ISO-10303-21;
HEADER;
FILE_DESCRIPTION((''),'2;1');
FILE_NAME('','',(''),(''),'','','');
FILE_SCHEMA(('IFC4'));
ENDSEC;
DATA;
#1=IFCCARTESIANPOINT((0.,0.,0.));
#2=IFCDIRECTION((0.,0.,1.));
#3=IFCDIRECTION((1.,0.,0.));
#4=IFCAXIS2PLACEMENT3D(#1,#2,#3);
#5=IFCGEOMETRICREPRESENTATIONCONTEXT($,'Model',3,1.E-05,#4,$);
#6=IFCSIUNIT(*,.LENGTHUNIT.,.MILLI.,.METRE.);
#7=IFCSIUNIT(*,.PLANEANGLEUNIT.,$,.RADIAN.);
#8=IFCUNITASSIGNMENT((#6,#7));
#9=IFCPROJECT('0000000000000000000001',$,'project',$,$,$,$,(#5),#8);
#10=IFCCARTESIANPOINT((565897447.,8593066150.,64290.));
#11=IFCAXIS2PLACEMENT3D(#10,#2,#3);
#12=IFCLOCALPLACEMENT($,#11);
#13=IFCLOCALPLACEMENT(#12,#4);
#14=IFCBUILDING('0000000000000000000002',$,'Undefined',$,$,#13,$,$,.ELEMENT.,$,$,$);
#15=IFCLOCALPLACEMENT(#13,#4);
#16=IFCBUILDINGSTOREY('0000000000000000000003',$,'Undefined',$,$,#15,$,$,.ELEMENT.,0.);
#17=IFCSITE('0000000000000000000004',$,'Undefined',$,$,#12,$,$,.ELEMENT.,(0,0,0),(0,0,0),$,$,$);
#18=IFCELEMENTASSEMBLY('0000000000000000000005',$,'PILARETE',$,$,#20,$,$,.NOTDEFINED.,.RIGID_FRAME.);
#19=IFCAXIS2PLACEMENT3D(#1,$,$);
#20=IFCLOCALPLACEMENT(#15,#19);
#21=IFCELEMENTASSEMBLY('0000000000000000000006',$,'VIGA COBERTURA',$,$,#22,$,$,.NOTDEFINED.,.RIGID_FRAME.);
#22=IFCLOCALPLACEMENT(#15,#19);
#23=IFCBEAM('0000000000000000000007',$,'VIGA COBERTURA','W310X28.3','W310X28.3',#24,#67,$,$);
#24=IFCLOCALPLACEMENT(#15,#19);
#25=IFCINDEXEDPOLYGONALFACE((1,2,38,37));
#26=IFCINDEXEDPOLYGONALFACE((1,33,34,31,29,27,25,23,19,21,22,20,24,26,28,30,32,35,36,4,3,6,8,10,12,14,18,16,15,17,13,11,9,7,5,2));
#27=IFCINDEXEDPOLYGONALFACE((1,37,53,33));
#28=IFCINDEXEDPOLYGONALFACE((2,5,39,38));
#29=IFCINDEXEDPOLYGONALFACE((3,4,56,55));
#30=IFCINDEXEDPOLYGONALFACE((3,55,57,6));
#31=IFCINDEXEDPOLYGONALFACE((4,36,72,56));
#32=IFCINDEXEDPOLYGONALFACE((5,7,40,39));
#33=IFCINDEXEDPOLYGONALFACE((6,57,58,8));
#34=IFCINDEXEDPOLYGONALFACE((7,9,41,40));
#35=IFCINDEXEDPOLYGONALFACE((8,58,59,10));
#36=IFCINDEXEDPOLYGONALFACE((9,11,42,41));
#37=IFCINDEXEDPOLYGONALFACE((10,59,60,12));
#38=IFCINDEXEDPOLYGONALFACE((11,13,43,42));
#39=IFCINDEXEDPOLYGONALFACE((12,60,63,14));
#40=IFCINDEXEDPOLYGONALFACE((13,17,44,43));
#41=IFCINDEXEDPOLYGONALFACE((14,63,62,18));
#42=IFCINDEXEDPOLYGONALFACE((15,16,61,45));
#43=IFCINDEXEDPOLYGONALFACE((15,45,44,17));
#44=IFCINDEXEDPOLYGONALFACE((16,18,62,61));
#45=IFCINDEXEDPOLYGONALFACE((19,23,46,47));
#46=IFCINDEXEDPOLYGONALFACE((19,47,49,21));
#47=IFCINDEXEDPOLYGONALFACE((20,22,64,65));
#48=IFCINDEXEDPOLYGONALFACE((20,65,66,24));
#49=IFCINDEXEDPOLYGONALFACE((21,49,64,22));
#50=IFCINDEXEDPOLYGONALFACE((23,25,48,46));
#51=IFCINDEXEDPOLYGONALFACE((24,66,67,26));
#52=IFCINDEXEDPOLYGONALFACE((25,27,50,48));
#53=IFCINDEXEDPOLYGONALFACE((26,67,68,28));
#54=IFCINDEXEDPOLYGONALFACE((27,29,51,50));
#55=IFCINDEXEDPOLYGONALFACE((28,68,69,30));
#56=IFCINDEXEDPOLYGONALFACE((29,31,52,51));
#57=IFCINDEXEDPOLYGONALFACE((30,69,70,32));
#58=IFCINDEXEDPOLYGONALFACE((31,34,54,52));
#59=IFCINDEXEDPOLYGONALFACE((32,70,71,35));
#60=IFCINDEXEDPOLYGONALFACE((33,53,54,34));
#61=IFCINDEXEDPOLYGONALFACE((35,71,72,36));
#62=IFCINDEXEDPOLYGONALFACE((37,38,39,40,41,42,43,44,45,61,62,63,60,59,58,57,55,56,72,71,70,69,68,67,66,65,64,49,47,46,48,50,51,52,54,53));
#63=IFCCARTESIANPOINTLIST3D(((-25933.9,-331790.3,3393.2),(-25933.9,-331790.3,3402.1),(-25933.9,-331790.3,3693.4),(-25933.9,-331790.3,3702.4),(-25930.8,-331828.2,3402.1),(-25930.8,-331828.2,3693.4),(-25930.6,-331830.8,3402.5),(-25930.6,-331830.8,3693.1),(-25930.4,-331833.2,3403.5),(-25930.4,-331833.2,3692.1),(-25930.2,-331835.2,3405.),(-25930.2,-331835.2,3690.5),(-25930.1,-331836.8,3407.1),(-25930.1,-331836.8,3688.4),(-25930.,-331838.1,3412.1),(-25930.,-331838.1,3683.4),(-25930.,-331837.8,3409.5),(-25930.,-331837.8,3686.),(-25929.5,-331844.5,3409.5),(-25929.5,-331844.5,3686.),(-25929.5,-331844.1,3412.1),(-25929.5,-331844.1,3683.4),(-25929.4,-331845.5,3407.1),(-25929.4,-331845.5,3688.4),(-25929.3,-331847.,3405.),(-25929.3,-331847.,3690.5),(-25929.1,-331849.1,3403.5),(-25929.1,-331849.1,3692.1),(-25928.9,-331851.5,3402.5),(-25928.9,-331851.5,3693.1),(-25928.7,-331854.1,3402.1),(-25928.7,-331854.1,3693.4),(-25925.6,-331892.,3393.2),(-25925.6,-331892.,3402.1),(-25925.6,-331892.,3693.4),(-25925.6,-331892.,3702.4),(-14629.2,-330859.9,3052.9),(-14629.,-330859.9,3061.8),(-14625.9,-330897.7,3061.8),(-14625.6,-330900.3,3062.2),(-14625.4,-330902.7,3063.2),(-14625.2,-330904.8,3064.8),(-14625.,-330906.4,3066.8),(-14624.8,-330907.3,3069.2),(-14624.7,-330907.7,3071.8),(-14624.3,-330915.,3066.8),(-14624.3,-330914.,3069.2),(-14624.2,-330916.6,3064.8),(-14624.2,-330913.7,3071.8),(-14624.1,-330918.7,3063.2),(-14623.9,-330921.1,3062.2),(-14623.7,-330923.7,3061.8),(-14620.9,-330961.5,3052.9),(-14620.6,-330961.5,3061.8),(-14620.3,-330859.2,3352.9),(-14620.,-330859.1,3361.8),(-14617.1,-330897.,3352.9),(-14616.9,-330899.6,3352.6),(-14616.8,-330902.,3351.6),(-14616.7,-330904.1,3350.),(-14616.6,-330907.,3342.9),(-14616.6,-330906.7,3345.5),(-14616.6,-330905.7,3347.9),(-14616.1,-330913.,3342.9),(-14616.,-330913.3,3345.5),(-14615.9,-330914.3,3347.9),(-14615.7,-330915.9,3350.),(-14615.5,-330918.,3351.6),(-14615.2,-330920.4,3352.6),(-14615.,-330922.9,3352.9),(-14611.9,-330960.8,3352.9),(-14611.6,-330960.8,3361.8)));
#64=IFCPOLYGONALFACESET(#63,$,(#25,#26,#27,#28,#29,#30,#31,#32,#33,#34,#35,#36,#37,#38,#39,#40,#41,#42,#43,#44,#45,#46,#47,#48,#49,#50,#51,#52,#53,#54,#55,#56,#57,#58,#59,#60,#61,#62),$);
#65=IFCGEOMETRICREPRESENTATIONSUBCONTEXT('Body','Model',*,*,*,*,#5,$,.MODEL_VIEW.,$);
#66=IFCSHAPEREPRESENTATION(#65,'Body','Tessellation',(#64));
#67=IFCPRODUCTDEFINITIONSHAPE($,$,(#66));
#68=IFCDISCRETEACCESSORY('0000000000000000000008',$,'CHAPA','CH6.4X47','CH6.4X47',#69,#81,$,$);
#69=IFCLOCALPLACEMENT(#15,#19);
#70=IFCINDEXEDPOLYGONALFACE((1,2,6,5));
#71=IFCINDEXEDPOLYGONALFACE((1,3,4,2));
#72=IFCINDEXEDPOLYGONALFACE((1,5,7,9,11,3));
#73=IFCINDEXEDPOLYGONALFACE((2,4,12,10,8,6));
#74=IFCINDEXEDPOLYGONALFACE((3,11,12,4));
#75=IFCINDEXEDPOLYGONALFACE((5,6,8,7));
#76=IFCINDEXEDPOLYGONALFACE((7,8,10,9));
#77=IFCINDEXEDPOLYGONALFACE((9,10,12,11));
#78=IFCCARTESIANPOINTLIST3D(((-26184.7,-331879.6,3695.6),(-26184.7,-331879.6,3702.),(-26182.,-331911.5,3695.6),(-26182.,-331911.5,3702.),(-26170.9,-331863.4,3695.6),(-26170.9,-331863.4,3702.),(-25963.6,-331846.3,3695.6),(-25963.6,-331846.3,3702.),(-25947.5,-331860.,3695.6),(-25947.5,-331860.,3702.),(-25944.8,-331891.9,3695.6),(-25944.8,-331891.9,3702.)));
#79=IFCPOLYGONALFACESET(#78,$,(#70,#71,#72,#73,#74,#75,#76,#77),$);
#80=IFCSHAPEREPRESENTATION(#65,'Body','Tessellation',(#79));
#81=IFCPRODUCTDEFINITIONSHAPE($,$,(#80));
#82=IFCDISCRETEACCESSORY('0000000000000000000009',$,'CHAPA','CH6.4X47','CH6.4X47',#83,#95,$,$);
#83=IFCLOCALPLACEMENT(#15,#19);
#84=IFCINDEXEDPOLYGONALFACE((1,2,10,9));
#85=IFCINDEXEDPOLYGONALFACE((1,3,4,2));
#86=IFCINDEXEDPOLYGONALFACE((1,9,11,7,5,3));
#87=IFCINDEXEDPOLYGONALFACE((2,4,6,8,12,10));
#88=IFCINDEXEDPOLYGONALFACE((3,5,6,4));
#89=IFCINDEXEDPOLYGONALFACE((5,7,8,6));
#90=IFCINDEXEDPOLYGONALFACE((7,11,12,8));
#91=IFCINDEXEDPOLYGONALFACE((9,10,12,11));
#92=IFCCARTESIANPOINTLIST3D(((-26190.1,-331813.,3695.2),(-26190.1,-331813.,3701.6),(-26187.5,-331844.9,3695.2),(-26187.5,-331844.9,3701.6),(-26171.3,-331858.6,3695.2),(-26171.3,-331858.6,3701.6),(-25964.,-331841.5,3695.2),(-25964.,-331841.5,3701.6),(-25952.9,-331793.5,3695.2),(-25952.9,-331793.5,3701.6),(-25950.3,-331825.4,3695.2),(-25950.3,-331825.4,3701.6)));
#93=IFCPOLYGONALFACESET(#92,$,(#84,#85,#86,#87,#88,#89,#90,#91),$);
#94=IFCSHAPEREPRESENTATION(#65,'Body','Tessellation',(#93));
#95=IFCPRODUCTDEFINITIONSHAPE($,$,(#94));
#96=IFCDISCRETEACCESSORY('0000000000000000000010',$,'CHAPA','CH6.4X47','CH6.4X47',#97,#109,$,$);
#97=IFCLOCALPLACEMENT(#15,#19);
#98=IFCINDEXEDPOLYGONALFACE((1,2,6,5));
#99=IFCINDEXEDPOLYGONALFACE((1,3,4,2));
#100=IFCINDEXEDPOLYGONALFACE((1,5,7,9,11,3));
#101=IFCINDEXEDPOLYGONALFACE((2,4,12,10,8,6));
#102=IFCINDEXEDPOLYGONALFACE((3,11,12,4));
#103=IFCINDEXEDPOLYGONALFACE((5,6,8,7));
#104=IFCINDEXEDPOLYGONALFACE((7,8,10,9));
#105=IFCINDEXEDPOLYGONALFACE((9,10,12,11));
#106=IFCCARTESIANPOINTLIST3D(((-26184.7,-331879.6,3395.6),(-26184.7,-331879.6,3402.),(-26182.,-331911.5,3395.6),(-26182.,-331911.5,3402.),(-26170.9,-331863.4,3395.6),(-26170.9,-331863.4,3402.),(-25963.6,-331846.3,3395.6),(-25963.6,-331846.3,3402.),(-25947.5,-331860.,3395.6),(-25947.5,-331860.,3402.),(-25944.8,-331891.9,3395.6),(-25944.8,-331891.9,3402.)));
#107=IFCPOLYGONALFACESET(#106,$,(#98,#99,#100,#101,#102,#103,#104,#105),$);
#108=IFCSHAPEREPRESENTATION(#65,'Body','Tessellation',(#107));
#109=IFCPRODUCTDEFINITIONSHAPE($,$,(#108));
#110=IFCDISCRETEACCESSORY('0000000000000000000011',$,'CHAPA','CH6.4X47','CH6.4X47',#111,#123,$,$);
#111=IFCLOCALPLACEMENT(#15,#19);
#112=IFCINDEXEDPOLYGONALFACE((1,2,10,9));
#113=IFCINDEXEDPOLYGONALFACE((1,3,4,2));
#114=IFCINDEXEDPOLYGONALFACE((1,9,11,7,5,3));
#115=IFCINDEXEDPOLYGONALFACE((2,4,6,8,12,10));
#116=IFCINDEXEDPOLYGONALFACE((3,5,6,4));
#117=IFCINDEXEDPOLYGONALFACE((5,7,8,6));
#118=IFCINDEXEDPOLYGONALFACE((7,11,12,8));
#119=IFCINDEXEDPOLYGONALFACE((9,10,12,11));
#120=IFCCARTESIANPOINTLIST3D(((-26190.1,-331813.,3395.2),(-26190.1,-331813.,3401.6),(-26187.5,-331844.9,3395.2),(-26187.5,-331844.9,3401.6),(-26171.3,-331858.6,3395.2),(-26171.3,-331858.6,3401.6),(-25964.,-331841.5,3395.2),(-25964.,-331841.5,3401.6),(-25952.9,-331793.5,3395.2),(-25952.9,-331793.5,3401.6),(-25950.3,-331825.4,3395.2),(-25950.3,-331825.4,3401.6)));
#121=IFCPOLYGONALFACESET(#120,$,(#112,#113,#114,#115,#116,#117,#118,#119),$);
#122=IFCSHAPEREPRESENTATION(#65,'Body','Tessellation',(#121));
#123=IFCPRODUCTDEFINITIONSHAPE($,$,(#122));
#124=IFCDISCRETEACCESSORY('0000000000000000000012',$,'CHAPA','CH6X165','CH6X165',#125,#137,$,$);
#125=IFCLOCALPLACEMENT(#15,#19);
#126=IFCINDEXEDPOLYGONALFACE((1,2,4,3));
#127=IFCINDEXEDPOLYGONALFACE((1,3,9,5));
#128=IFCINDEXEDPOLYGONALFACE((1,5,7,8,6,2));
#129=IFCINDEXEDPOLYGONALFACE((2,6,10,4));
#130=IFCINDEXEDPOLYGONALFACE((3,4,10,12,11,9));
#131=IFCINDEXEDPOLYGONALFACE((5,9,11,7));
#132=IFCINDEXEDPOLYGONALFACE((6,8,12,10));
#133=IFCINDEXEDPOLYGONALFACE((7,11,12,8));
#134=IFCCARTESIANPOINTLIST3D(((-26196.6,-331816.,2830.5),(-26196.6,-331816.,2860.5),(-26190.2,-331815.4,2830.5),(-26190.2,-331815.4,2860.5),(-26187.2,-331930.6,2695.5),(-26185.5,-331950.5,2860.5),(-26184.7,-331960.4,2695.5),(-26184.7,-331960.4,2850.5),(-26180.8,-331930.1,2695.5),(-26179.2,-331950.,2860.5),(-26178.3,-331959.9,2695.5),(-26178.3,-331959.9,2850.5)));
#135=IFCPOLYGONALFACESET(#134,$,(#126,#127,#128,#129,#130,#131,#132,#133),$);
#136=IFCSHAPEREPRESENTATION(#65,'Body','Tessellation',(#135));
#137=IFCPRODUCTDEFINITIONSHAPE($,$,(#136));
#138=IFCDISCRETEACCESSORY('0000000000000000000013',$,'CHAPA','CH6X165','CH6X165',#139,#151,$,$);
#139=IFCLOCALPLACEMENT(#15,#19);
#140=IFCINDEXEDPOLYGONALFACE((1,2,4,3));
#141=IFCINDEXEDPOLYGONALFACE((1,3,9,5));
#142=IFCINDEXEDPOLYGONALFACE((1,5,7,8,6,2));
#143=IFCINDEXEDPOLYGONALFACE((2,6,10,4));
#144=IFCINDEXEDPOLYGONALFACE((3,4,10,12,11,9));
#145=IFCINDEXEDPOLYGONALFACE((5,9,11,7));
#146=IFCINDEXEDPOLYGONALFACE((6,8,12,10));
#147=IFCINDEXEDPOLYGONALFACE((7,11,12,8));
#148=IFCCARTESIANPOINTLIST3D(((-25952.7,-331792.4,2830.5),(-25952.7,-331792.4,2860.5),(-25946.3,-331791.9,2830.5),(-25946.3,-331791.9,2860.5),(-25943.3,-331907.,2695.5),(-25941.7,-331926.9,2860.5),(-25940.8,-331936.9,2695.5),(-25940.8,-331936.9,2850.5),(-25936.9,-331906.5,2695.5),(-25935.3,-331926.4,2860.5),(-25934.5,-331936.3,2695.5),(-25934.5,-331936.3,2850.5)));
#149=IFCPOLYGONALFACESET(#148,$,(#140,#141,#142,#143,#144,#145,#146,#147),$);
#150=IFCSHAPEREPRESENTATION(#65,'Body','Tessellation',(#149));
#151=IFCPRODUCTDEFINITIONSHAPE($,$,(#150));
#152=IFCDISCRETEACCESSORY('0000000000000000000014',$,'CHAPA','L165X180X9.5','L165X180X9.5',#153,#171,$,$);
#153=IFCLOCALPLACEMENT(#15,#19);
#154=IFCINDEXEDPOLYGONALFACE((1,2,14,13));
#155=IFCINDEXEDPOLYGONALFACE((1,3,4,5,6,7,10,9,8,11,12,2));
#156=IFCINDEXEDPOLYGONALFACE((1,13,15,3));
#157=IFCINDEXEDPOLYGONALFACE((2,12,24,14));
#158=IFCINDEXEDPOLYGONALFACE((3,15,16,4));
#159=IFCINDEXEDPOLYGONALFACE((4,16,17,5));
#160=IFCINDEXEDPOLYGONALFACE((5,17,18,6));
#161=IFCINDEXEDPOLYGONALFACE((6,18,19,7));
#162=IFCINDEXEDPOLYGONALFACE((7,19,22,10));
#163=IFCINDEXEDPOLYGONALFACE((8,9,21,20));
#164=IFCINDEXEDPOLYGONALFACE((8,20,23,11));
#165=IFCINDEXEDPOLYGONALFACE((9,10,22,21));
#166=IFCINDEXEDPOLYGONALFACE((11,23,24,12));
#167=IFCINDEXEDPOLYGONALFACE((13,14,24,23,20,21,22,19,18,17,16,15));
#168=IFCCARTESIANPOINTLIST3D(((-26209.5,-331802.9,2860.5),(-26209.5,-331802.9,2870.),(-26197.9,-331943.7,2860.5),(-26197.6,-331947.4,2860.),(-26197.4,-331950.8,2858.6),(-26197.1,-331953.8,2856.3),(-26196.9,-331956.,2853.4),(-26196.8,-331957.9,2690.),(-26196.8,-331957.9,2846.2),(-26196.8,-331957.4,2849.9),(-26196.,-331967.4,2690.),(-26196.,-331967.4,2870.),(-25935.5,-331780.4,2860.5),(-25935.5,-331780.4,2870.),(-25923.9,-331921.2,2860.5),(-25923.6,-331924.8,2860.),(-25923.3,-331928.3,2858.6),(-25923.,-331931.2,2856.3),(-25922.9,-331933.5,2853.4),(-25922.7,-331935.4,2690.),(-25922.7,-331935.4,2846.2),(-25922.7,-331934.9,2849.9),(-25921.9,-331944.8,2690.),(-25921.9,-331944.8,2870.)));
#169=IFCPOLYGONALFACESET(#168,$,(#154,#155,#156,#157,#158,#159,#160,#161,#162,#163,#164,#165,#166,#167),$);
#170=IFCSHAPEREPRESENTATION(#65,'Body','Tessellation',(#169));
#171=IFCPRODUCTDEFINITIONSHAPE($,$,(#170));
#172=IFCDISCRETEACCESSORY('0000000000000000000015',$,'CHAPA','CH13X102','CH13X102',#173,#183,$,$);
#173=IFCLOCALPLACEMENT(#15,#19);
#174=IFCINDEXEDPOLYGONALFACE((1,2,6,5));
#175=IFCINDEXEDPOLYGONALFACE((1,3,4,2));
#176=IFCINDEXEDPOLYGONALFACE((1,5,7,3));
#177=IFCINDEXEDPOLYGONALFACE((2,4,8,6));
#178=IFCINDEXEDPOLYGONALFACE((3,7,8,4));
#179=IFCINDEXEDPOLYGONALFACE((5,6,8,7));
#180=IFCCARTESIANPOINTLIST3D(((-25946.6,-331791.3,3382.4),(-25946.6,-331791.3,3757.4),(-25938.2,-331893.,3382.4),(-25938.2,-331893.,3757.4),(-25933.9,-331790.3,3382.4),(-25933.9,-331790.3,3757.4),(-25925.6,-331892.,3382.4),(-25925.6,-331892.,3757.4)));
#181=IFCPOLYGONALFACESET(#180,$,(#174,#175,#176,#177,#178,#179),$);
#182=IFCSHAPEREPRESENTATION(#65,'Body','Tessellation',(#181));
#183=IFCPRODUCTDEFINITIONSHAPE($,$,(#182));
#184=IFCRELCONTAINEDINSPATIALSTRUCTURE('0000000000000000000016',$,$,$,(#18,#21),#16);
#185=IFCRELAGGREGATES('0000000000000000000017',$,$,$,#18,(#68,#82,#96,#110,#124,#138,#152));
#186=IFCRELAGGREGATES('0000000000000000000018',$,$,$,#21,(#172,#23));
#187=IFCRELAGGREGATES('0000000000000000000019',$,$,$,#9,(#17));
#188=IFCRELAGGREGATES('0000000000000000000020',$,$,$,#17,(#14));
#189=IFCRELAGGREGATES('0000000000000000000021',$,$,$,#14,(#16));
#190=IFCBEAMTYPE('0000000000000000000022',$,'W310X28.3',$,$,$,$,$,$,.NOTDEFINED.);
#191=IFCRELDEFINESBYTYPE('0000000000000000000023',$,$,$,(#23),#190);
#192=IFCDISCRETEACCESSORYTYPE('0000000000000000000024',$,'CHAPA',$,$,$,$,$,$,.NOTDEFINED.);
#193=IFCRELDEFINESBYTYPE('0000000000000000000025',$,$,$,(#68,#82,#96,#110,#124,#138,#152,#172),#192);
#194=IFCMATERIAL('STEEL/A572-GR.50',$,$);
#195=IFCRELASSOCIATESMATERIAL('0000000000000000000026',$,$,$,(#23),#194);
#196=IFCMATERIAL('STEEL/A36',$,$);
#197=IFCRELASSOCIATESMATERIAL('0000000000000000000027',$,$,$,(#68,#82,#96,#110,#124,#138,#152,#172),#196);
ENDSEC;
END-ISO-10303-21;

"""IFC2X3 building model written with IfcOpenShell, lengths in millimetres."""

from ifc_helpers import new_model, si_unit, frame, origin_with_axes, origin_2d_with_axis, place, context, subcontext, project, spatial, polyline, i_section, l_section, outline, extrude, clip, halfspace, material, type_object, element, aggregate, save


model = new_model("IFC2X3")

# Units and contexts
model_context = context("Model", 3, precision=1e-05, world=origin_with_axes())
body_context = subcontext(model_context, "Body", "Model", "MODEL_VIEW")
ifc_project = project(units=[si_unit("LENGTHUNIT", "METRE", prefix="MILLI"), si_unit("PLANEANGLEUNIT", "RADIAN")], contexts=[model_context])

# Site, building, storey
site_placement = place(None, frame((565897447.0, 8593066150.0, 64290.0), z_axis=(0.0, 0.0, 1.0), x_axis=(1.0, 0.0, 0.0)))
site = spatial("IfcSite", under=ifc_project, at=site_placement, Name="Undefined", CompositionType="ELEMENT", RefLatitude=(0, 0, 0), RefLongitude=(0, 0, 0))
building_placement = place(site_placement, origin_with_axes())
building = spatial("IfcBuilding", under=site, at=building_placement, Name="Undefined", CompositionType="ELEMENT")
storey_placement = place(building_placement, origin_with_axes())
storey = spatial("IfcBuildingStorey", under=building, at=storey_placement, Name="Undefined", CompositionType="ELEMENT", Elevation=0.0)

# Element assembly
assembly_1_placement = place(storey_placement, origin_with_axes())
assembly_1 = element("IfcElementAssembly", 1, at=assembly_1_placement, inside=storey, Name="PILARETE", AssemblyPlace="NOTDEFINED", PredefinedType="RIGID_FRAME")
ifc_material_1 = material(Name="STEEL/A572-GR.50")

# Element assembly, beam
ifc_material_2 = material(Name="STEEL/A36")
assembly_2_placement = place(storey_placement, origin_with_axes())
assembly_2 = element("IfcElementAssembly", 2, at=assembly_2_placement, inside=storey, Name="VIGA COBERTURA", AssemblyPlace="NOTDEFINED", PredefinedType="RIGID_FRAME")
beam_type_1 = type_object("IfcBeamType", Name="W310X28.3", PredefinedType="NOTDEFINED")
beam_1_placement = place(assembly_2_placement, frame((-25947.0, -331842.5, 3548.3), z_axis=(-0.029885, -0.00246, -0.99955), x_axis=(0.996182, 0.081989, -0.029987)))
beam_1 = element("IfcBeam", 3, at=beam_1_placement, type_object=beam_type_1, material=ifc_material_1, Name="VIGA COBERTURA", Description="W310X28.3", ObjectType="W310X28.3", context=body_context, shape_type="Clipping", body=[
    clip(extrude(i_section(OverallWidth=102.0, OverallDepth=309.0, WebThickness=6.0, FlangeThickness=8.9, FilletRadius=10.0, at=origin_2d_with_axis()), frame((11370.0, 0.0, 0.0), z_axis=(-1.0, 0.0, 0.0), x_axis=(0.0, -1.0, 0.0)), (0.0, 0.0, 1.0), 11370.0), halfspace(frame((12.7, 51.0, -154.5), z_axis=(-0.99955, 0.0, 0.029987), x_axis=(0.029987, 0.0, 0.99955)), False)),
])

# Shared definitions
discrete_accessory_type_1 = type_object("IfcDiscreteAccessoryType", Name="CHAPA")

# Discrete accessories
discrete_accessory_1_placement = place(assembly_1_placement, frame((-25948.7, -331845.1, 3698.8), z_axis=(0.0, 0.0, -1.0), x_axis=(0.082025, -0.99663, 0.0)))
discrete_accessory_1 = element("IfcDiscreteAccessory", 4, at=discrete_accessory_1_placement, type_object=discrete_accessory_type_1, material=ifc_material_2, Name="CHAPA", Description="CH6.4X47", ObjectType="CH6.4X47", context=body_context, shape_type="SweptSolid", body=[
    extrude(outline(polyline([(0.0, 15.0), (15.0, 0.0), (47.0, 0.0), (47.0, 238.0), (15.0, 238.0), (0.0, 223.0), (0.0, 15.0)])), frame((0.0, 0.0, -3.2), z_axis=(0.0, 0.0, 1.0), x_axis=(1.0, 0.0, 0.0)), (0.0, 0.0, 1.0), 6.4),
])
discrete_accessory_2_placement = place(assembly_1_placement, frame((-25949.1, -331840.3, 3698.4), z_axis=(0.0, 0.0, 1.0), x_axis=(-0.082025, 0.99663, 0.0)))
discrete_accessory_2 = element("IfcDiscreteAccessory", 5, at=discrete_accessory_2_placement, type_object=discrete_accessory_type_1, material=ifc_material_2, Name="CHAPA", Description="CH6.4X47", ObjectType="CH6.4X47", context=body_context, shape_type="SweptSolid", body=[
    extrude(outline(polyline([(0.0, 15.0), (15.0, 0.0), (47.0, 0.0), (47.0, 238.0), (15.0, 238.0), (0.0, 223.0), (0.0, 15.0)])), frame((0.0, 0.0, -3.2), z_axis=(0.0, 0.0, 1.0), x_axis=(1.0, 0.0, 0.0)), (0.0, 0.0, 1.0), 6.4),
])
discrete_accessory_3_placement = place(assembly_1_placement, frame((-25948.7, -331845.1, 3398.8), z_axis=(0.0, 0.0, -1.0), x_axis=(0.082025, -0.99663, 0.0)))
discrete_accessory_3 = element("IfcDiscreteAccessory", 6, at=discrete_accessory_3_placement, type_object=discrete_accessory_type_1, material=ifc_material_2, Name="CHAPA", Description="CH6.4X47", ObjectType="CH6.4X47", context=body_context, shape_type="SweptSolid", body=[
    extrude(outline(polyline([(0.0, 15.0), (15.0, 0.0), (47.0, 0.0), (47.0, 238.0), (15.0, 238.0), (0.0, 223.0), (0.0, 15.0)])), frame((0.0, 0.0, -3.2), z_axis=(0.0, 0.0, 1.0), x_axis=(1.0, 0.0, 0.0)), (0.0, 0.0, 1.0), 6.4),
])
discrete_accessory_4_placement = place(assembly_1_placement, frame((-25949.1, -331840.3, 3398.4), z_axis=(0.0, 0.0, 1.0), x_axis=(-0.082025, 0.99663, 0.0)))
discrete_accessory_4 = element("IfcDiscreteAccessory", 7, at=discrete_accessory_4_placement, type_object=discrete_accessory_type_1, material=ifc_material_2, Name="CHAPA", Description="CH6.4X47", ObjectType="CH6.4X47", context=body_context, shape_type="SweptSolid", body=[
    extrude(outline(polyline([(0.0, 15.0), (15.0, 0.0), (47.0, 0.0), (47.0, 238.0), (15.0, 238.0), (0.0, 223.0), (0.0, 15.0)])), frame((0.0, 0.0, -3.2), z_axis=(0.0, 0.0, 1.0), x_axis=(1.0, 0.0, 0.0)), (0.0, 0.0, 1.0), 6.4),
])
discrete_accessory_5_placement = place(assembly_1_placement, frame((-26181.5, -331960.2, 2860.5), z_axis=(0.99663, 0.082025, -0.000004), x_axis=(-0.000004, 0.0, -1.0)))
discrete_accessory_5 = element("IfcDiscreteAccessory", 8, at=discrete_accessory_5_placement, type_object=discrete_accessory_type_1, material=ifc_material_2, Name="CHAPA", Description="CH6X165", ObjectType="CH6X165", context=body_context, shape_type="SweptSolid", body=[
    extrude(outline(polyline([(0.0, 10.0), (10.0, 0.0), (165.0, 0.0), (165.0, 30.0), (30.0, 145.0), (0.0, 145.0), (0.0, 10.0)])), frame((0.0, 0.0, -3.2), z_axis=(0.0, 0.0, 1.0), x_axis=(1.0, 0.0, 0.0)), (0.0, 0.0, 1.0), 6.4),
])
discrete_accessory_6_placement = place(assembly_1_placement, frame((-25937.6, -331936.6, 2860.5), z_axis=(0.99663, 0.082025, 0.000004), x_axis=(0.000004, 0.0, -1.0)))
discrete_accessory_6 = element("IfcDiscreteAccessory", 9, at=discrete_accessory_6_placement, type_object=discrete_accessory_type_1, material=ifc_material_2, Name="CHAPA", Description="CH6X165", ObjectType="CH6X165", context=body_context, shape_type="SweptSolid", body=[
    extrude(outline(polyline([(0.0, 10.0), (10.0, 0.0), (165.0, 0.0), (165.0, 30.0), (30.0, 145.0), (0.0, 145.0), (0.0, 10.0)])), frame((0.0, 0.0, -3.2), z_axis=(0.0, 0.0, 1.0), x_axis=(1.0, 0.0, 0.0)), (0.0, 0.0, 1.0), 6.4),
])
discrete_accessory_7_placement = place(assembly_1_placement, frame((-25928.7, -331862.6, 2780.0), z_axis=(-0.082025, 0.99663, 0.0), x_axis=(-0.99663, -0.082025, 0.0)))
discrete_accessory_7 = element("IfcDiscreteAccessory", 10, at=discrete_accessory_7_placement, type_object=discrete_accessory_type_1, material=ifc_material_2, Name="CHAPA", Description="L165X180X9.5", ObjectType="L165X180X9.5", context=body_context, shape_type="SweptSolid", body=[
    extrude(l_section(Depth=165.0, Width=180.0, Thickness=9.5, FilletRadius=14.2, at=origin_2d_with_axis()), frame((275.0, 0.0, 0.0), z_axis=(-1.0, 0.0, 0.0), x_axis=(0.0, -1.0, 0.0)), (0.0, 0.0, 1.0), 275.0),
])
aggregate(assembly_1, [discrete_accessory_1, discrete_accessory_2, discrete_accessory_3, discrete_accessory_4, discrete_accessory_5, discrete_accessory_6, discrete_accessory_7])
discrete_accessory_8_placement = place(assembly_2_placement, frame((-25936.1, -331841.6, 3757.4), z_axis=(-0.99663, -0.082025, 0.0), x_axis=(0.0, 0.0, -1.0)))
discrete_accessory_8 = element("IfcDiscreteAccessory", 11, at=discrete_accessory_8_placement, type_object=discrete_accessory_type_1, material=ifc_material_2, Name="CHAPA", Description="CH13X102", ObjectType="CH13X102", context=body_context, shape_type="SweptSolid", body=[
    extrude(outline(polyline([(375.0, -51.0), (0.0, -51.0), (0.0, 51.0), (375.0, 51.0), (375.0, -51.0)])), frame((0.0, 0.0, -6.3), z_axis=(0.0, 0.0, 1.0), x_axis=(1.0, 0.0, 0.0)), (0.0, 0.0, 1.0), 12.7),
])
aggregate(assembly_2, [discrete_accessory_8, beam_1])

save(model, "model.ifc")
